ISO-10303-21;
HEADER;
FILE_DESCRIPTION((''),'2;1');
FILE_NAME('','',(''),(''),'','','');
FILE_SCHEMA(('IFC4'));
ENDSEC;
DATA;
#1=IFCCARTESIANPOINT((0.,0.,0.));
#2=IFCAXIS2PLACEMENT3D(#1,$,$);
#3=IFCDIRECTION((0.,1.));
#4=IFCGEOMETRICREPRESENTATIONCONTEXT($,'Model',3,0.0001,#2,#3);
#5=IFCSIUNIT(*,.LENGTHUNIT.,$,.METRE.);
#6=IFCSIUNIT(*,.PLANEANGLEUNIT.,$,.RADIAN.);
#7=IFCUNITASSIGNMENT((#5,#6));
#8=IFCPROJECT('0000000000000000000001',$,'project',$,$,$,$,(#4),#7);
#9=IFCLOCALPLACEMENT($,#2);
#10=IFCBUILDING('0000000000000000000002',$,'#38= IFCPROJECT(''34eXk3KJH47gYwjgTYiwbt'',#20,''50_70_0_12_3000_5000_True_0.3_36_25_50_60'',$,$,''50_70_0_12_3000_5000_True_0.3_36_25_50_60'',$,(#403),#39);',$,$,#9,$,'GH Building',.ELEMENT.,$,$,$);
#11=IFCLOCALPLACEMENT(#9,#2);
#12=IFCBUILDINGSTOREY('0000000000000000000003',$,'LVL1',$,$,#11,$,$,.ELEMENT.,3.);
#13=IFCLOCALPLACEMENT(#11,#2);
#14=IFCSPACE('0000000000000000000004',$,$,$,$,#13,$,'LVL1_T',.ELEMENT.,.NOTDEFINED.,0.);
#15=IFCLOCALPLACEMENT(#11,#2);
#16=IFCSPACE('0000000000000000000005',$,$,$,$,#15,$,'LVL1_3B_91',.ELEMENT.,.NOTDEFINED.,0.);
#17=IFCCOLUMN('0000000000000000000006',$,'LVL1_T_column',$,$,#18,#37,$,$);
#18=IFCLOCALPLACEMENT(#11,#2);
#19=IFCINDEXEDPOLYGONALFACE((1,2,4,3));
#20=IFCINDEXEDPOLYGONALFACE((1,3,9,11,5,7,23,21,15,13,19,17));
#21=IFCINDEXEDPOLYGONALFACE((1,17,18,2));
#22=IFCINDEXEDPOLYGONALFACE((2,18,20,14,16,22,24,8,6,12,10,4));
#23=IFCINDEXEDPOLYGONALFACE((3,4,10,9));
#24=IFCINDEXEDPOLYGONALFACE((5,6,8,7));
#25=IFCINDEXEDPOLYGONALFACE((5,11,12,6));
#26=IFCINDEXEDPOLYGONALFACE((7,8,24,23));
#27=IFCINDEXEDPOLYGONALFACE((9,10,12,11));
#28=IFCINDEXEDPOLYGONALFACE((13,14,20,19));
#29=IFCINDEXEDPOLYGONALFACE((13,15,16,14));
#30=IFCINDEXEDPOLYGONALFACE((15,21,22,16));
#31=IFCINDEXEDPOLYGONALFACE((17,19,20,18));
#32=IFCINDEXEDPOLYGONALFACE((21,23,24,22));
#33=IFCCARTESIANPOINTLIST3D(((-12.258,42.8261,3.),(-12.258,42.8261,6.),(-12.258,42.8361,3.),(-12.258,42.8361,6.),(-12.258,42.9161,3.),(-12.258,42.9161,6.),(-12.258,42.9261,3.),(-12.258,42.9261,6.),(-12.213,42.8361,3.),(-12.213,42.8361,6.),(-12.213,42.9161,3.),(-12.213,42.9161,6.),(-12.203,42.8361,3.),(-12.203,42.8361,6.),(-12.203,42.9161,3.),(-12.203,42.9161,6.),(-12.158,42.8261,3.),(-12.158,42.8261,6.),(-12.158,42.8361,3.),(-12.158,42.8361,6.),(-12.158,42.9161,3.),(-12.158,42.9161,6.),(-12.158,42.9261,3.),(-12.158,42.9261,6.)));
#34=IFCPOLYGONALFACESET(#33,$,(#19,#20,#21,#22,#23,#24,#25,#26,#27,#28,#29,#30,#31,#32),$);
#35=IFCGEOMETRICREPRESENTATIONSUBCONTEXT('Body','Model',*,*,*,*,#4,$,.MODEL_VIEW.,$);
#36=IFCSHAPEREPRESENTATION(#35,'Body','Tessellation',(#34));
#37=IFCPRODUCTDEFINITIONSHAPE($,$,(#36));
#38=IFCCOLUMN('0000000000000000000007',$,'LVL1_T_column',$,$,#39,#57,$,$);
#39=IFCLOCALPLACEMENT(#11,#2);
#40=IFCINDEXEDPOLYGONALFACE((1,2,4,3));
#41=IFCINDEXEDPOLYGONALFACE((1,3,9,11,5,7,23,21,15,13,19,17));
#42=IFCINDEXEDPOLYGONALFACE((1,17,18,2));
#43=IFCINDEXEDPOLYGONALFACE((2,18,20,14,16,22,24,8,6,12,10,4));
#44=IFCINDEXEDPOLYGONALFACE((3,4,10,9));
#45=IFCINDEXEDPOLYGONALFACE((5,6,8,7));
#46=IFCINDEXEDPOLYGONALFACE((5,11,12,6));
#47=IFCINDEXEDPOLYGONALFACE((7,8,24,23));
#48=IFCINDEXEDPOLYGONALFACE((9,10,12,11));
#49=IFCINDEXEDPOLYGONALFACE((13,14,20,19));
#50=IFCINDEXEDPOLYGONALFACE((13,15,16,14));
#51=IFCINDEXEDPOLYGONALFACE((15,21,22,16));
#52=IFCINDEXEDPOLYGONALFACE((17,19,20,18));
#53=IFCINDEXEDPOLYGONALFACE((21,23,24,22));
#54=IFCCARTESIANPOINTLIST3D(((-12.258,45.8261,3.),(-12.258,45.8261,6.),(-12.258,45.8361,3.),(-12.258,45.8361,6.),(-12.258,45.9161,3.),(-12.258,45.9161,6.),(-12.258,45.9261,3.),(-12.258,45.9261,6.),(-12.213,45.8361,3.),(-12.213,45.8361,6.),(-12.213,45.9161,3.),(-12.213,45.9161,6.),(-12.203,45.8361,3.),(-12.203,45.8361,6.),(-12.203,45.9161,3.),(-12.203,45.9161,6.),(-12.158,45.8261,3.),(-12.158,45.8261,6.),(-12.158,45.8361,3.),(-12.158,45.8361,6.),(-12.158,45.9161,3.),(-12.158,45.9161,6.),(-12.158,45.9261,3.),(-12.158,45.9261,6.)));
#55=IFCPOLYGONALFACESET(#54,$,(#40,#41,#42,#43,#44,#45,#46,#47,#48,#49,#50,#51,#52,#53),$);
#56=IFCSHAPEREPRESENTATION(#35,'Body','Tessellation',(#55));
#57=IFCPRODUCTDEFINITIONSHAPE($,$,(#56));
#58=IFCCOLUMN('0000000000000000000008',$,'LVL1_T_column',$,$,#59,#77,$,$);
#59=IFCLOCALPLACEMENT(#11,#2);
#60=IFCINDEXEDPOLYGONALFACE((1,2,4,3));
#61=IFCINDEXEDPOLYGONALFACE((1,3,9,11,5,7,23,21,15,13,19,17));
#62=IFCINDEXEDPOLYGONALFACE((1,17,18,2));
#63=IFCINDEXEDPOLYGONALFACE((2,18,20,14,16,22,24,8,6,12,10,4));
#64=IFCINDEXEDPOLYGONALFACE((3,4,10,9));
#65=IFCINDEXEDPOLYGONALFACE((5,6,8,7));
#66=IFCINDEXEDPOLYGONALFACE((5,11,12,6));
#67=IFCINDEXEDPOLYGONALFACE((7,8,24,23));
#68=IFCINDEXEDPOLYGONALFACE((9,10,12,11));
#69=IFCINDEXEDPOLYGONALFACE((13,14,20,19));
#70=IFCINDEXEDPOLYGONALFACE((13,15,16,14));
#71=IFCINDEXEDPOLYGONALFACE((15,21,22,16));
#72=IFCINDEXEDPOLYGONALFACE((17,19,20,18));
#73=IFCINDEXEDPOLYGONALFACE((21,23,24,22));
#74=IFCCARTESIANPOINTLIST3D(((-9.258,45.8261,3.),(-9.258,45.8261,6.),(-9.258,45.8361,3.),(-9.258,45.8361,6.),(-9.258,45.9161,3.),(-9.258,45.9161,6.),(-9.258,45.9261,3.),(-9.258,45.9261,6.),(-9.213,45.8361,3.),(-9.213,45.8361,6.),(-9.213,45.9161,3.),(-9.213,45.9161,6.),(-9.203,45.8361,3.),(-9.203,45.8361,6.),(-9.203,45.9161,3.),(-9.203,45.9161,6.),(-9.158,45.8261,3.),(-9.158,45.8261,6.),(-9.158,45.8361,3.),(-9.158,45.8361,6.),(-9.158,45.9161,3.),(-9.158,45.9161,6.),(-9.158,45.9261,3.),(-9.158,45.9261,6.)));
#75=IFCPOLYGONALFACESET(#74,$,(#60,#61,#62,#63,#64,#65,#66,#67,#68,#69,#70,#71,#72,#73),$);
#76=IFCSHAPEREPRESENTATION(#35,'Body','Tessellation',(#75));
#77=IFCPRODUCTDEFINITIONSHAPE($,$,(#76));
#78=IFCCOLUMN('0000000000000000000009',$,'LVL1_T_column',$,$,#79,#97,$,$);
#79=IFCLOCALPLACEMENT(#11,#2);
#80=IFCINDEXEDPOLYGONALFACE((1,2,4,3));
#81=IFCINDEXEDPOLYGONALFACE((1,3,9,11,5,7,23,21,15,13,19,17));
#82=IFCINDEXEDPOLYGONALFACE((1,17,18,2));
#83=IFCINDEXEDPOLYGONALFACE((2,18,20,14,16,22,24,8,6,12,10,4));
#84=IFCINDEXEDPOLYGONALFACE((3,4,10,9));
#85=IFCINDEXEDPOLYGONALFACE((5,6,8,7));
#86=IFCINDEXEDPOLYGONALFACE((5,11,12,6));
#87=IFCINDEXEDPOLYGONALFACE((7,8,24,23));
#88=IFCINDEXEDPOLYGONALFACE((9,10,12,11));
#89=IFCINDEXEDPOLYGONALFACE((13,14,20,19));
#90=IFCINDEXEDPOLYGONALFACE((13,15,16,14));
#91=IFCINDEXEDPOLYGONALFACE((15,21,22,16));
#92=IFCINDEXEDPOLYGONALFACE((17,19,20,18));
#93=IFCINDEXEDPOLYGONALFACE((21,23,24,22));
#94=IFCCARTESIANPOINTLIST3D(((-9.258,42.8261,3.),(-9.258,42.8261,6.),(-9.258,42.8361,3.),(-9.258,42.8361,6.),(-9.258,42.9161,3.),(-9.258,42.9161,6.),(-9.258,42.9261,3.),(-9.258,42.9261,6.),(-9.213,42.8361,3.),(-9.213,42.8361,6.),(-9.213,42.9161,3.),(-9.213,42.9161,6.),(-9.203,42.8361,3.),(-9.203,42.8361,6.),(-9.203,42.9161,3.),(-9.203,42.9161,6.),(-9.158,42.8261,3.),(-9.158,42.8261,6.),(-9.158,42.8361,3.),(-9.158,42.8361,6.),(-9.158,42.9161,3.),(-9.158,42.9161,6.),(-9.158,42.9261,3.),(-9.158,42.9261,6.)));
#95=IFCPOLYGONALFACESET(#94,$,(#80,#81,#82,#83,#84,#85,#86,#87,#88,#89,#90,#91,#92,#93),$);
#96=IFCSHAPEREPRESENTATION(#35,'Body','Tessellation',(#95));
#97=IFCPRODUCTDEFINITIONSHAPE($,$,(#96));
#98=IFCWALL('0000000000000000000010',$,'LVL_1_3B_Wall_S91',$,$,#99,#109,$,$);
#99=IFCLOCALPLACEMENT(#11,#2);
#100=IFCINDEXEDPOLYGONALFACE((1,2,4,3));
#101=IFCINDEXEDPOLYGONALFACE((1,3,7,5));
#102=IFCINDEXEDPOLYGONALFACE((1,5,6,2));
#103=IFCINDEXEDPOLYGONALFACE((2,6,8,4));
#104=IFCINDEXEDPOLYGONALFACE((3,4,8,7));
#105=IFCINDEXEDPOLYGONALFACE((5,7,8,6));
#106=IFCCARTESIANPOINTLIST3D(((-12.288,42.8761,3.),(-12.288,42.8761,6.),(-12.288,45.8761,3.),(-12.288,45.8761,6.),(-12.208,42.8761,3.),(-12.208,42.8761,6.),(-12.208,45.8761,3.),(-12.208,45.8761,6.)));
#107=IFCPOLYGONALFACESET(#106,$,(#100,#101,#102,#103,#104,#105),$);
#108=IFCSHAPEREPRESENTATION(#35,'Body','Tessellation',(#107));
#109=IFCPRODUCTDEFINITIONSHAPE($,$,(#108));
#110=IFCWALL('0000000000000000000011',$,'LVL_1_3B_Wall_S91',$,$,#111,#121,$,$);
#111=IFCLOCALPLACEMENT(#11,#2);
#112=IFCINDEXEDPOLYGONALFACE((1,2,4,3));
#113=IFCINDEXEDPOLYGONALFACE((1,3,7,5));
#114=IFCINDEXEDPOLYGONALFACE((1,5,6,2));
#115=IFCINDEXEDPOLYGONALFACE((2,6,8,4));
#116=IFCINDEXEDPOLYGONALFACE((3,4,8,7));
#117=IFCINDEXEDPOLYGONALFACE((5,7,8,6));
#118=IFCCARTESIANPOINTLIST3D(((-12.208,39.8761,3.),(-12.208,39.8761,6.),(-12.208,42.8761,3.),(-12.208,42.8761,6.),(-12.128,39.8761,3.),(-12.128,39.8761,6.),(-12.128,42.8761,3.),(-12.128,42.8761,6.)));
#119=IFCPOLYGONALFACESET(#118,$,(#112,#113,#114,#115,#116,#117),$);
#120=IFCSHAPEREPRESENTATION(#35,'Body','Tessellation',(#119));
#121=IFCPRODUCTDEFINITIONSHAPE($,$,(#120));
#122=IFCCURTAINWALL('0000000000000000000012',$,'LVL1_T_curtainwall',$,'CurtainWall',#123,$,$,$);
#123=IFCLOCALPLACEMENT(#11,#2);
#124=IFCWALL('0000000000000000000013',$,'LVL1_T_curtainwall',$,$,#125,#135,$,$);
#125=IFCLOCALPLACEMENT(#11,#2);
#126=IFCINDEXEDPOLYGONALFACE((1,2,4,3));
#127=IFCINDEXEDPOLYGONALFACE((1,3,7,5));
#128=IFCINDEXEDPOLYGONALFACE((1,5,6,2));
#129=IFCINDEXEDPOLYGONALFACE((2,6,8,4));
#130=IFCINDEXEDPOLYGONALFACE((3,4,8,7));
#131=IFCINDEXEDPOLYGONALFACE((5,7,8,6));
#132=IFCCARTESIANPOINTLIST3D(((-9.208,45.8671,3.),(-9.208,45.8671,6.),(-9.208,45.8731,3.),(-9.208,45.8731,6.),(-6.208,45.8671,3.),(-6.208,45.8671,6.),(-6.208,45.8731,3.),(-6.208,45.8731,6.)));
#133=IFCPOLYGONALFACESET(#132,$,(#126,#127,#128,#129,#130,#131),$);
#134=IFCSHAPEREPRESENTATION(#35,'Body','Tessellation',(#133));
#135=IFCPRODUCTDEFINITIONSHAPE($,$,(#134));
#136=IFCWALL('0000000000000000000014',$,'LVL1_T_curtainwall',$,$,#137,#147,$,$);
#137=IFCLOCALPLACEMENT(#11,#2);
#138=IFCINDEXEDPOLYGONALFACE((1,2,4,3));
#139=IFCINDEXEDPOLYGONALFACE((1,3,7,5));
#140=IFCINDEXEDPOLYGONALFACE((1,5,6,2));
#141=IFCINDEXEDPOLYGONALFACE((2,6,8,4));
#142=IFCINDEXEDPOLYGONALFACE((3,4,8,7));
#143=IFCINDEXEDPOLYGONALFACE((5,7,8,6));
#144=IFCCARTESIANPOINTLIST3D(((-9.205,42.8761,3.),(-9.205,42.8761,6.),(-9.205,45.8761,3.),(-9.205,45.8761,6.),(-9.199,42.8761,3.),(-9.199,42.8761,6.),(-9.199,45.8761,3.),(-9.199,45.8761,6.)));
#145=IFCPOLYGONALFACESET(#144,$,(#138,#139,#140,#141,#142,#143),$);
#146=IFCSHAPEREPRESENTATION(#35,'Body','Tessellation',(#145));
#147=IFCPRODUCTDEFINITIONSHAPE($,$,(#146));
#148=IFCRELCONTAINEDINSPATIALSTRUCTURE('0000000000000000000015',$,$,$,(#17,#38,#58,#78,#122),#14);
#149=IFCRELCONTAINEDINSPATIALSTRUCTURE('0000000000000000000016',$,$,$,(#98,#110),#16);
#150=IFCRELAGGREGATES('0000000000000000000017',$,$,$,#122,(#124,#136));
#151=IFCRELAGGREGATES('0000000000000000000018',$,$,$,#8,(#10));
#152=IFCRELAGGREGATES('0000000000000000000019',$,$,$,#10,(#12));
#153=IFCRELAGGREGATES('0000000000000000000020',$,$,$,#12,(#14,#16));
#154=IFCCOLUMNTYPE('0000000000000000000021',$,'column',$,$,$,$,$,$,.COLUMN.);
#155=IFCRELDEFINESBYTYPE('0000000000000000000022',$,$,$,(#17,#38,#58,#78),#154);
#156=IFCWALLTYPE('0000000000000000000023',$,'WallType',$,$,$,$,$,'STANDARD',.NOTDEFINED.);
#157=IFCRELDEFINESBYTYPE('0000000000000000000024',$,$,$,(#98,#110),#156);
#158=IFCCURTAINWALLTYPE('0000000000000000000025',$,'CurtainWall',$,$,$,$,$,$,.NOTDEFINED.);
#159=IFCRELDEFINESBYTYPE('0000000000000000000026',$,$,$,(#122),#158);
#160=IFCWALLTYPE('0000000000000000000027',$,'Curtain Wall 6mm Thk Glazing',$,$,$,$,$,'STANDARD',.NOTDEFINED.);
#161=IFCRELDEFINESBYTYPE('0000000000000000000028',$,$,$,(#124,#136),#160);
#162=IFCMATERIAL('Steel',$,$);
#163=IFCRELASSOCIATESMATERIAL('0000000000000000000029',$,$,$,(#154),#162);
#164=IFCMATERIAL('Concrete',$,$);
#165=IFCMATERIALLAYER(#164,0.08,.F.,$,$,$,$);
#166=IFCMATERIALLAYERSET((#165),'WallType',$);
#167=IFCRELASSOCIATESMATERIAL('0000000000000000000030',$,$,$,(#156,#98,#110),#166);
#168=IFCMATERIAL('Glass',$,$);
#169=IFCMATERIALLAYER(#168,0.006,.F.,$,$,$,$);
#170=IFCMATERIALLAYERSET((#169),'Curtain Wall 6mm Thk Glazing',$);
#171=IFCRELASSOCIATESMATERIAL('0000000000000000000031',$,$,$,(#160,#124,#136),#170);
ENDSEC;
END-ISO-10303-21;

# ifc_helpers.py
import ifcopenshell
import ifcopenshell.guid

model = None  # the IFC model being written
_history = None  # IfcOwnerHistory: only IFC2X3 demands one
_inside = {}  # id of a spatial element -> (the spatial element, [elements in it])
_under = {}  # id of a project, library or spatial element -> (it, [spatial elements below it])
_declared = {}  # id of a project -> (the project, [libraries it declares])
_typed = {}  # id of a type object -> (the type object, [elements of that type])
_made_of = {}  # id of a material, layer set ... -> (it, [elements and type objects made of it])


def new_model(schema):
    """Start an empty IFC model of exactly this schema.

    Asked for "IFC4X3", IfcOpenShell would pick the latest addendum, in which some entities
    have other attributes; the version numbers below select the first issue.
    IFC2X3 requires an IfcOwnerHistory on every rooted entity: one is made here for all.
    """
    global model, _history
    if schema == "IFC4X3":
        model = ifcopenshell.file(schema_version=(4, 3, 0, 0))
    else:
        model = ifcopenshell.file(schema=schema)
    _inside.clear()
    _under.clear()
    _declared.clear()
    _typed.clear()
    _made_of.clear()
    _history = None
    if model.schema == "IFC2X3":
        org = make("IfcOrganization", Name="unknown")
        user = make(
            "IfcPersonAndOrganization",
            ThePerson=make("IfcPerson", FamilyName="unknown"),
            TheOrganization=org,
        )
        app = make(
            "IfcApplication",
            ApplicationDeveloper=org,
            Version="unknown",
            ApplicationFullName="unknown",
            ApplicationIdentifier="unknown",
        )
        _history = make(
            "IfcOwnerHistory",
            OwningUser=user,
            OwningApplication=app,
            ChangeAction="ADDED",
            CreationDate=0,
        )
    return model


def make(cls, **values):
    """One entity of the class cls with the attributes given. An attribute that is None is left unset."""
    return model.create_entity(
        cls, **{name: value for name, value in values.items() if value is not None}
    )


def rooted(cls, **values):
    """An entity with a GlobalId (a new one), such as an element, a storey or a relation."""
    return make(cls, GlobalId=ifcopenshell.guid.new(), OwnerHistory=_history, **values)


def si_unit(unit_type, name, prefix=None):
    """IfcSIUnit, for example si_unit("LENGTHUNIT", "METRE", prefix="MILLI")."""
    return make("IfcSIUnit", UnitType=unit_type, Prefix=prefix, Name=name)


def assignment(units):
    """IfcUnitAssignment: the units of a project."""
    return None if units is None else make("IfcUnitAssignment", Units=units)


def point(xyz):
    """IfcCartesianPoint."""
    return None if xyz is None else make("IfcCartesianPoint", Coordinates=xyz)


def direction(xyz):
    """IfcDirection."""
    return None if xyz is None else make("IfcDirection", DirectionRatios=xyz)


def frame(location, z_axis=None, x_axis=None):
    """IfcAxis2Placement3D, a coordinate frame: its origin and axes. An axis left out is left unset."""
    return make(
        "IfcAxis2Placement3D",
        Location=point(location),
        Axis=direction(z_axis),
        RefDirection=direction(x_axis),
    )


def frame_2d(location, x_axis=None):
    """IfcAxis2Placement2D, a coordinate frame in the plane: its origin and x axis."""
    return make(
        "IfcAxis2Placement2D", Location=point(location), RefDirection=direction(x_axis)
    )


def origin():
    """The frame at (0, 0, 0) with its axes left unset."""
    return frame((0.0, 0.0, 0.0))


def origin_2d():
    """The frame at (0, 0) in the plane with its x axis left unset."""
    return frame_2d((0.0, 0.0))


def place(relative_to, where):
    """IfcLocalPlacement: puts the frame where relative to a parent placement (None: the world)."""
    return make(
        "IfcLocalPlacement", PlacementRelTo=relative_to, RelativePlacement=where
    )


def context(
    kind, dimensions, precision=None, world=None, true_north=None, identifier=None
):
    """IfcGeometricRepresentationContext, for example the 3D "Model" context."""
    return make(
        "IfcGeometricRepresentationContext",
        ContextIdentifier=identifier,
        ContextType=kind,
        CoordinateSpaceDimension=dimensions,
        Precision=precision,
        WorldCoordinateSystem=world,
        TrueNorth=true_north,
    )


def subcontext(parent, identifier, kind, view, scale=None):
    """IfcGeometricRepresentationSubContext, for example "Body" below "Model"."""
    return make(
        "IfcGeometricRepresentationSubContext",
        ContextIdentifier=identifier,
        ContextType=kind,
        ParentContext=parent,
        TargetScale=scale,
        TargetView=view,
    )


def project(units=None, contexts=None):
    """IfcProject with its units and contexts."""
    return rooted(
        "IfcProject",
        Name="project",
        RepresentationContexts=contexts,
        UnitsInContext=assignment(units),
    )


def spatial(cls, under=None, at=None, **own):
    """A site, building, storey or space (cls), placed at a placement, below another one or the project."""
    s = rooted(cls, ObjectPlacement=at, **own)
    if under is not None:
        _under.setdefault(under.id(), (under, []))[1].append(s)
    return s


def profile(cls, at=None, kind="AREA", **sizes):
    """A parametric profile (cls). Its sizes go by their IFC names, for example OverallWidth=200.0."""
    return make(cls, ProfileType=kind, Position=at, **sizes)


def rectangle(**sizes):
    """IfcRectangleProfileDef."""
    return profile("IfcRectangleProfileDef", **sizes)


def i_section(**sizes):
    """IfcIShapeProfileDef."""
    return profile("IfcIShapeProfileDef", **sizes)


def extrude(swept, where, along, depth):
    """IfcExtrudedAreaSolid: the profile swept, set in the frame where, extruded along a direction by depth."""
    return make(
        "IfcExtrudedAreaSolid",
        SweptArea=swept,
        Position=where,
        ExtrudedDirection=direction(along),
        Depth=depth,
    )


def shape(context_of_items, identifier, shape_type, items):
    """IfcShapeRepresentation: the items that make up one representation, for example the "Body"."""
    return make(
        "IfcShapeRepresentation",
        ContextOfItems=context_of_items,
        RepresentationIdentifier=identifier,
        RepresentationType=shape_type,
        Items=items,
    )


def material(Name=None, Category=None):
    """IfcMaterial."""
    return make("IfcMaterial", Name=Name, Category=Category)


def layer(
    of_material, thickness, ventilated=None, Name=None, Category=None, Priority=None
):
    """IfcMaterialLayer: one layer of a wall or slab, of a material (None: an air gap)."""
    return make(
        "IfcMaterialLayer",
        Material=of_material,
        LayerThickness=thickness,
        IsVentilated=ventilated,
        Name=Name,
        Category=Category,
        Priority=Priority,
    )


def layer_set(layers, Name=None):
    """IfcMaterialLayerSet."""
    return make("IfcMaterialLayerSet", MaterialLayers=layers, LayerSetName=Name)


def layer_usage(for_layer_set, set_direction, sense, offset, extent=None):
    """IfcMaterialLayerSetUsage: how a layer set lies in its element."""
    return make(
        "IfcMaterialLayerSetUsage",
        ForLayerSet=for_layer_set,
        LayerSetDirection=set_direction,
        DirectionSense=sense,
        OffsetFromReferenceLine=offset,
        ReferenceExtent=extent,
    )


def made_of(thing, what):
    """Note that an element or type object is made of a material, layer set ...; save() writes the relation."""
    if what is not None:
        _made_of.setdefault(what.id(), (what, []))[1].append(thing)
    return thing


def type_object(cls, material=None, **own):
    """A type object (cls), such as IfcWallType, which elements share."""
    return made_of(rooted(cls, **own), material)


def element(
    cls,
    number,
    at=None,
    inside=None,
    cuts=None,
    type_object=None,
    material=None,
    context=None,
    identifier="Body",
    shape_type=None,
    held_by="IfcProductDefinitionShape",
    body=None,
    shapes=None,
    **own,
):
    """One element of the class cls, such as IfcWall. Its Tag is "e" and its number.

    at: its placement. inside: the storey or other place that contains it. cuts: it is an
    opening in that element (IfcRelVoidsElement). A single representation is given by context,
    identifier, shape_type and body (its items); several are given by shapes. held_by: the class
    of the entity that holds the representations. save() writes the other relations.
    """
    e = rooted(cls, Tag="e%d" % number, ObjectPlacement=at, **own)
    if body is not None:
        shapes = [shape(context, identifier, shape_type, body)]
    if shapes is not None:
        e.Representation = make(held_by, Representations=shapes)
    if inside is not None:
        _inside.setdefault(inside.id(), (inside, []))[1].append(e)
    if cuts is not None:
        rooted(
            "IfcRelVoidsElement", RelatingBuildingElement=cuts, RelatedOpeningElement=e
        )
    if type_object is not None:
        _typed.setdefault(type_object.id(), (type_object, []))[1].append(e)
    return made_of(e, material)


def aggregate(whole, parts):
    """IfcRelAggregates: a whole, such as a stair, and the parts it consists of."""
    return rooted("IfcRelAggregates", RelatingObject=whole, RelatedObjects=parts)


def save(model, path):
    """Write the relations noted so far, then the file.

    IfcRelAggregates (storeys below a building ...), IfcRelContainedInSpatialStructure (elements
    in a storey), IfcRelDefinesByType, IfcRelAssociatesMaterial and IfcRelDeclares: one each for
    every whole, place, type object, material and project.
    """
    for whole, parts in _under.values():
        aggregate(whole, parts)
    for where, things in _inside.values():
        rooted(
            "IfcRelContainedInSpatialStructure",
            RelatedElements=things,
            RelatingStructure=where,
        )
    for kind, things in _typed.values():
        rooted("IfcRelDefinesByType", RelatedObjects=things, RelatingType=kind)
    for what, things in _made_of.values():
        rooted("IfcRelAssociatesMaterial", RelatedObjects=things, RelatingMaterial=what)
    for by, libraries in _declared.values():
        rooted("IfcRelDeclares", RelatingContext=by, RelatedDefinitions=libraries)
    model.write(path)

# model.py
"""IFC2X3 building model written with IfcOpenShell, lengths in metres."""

from ifc_helpers import new_model, si_unit, direction, frame, frame_2d, origin, origin_2d, place, context, subcontext, project, spatial, rectangle, i_section, extrude, material, layer, layer_set, layer_usage, type_object, element, aggregate, save


model = new_model("IFC2X3")

# Units and contexts
model_context = context("Model", 3, precision=0.0001, world=origin(), true_north=direction((0.0, 1.0)))
body_context = subcontext(model_context, "Body", "Model", "MODEL_VIEW")
ifc_project = project(units=[si_unit("LENGTHUNIT", "METRE"), si_unit("PLANEANGLEUNIT", "RADIAN")], contexts=[model_context])

# Building, storey, space
building_placement = place(None, origin())
building = spatial("IfcBuilding", under=ifc_project, at=building_placement, Name="#38= IFCPROJECT('34eXk3KJH47gYwjgTYiwbt',#20,'50_70_0_12_3000_5000_True_0.3_36_25_50_60',$,$,'50_70_0_12_3000_5000_True_0.3_36_25_50_60',$,(#403),#39);", LongName="GH Building", CompositionType="ELEMENT")
storey_placement = place(building_placement, origin())
storey = spatial("IfcBuildingStorey", under=building, at=storey_placement, Name="LVL1", CompositionType="ELEMENT", Elevation=3.0)
space_1_placement = place(storey_placement, origin())
space_1 = spatial("IfcSpace", under=storey, at=space_1_placement, LongName="LVL1_T", CompositionType="ELEMENT", InteriorOrExteriorSpace="NOTDEFINED", ElevationWithFlooring=0.0)

# Columns
ifc_material_1 = material(Name="Steel")
column_type = type_object("IfcColumnType", Name="column", PredefinedType="COLUMN", material=ifc_material_1)
for number, where, name in (
    (1, (-12.208, 42.8761, 3.0), "LVL1_T_column"),
    (2, (-12.208, 45.8761, 3.0), "LVL1_T_column"),
    (3, (-9.208, 45.8761, 3.0), "LVL1_T_column"),
    (4, (-9.208, 42.8761, 3.0), "LVL1_T_column"),
):
    element("IfcColumn", number, at=place(space_1_placement, frame(where)), inside=space_1, type_object=column_type, Name=name, context=body_context, shape_type="SweptSolid", body=[
        extrude(i_section(OverallWidth=0.1, OverallDepth=0.1, WebThickness=0.01, FlangeThickness=0.01, at=origin_2d()), origin(), (0.0, 0.0, 1.0), 3.0),
    ])

# Shared definitions
ifc_material_2 = material(Name="Concrete")
ifc_layer_1 = layer(ifc_material_2, 0.08, ventilated=False)
ifc_layer_set_1 = layer_set([ifc_layer_1], Name="WallType")
wall_type_1 = type_object("IfcWallType", Name="WallType", ElementType="STANDARD", PredefinedType="NOTDEFINED", material=ifc_layer_set_1)

# Shared definitions
space_2_placement = place(storey_placement, origin())
space_2 = spatial("IfcSpace", under=storey, at=space_2_placement, LongName="LVL1_3B_91", CompositionType="ELEMENT", InteriorOrExteriorSpace="NOTDEFINED", ElevationWithFlooring=0.0)

# Walls
ifc_layer_usage_1 = layer_usage(ifc_layer_set_1, "AXIS2", "NEGATIVE", 0.0)
wall_1_placement = place(space_2_placement, frame((-12.208, 45.8761, 3.0), z_axis=(0.0, 0.0, 1.0), x_axis=(0.0, -1.0, 0.0)))
element("IfcWall", 5, at=wall_1_placement, inside=space_2, type_object=wall_type_1, material=ifc_layer_usage_1, Name="LVL_1_3B_Wall_S91", context=body_context, shape_type="SweptSolid", body=[
    extrude(rectangle(XDim=3.0, YDim=0.08, at=frame_2d((1.5, -0.04))), origin(), (0.0, 0.0, 1.0), 3.0),
])
ifc_layer_usage_2 = layer_usage(ifc_layer_set_1, "AXIS2", "NEGATIVE", 0.0)
wall_2_placement = place(space_2_placement, frame((-12.208, 39.8761, 3.0), z_axis=(0.0, 0.0, 1.0), x_axis=(0.0, 1.0, 0.0)))
element("IfcWall", 6, at=wall_2_placement, inside=space_2, type_object=wall_type_1, material=ifc_layer_usage_2, Name="LVL_1_3B_Wall_S91", context=body_context, shape_type="SweptSolid", body=[
    extrude(rectangle(XDim=3.0, YDim=0.08, at=frame_2d((1.5, -0.04))), origin(), (0.0, 0.0, 1.0), 3.0),
])

# Curtain wall, walls
curtain_wall_type = type_object("IfcCurtainWallType", Name="CurtainWall", PredefinedType="NOTDEFINED")
curtain_wall_placement = place(None, origin())
curtain_wall = element("IfcCurtainWall", 7, at=curtain_wall_placement, inside=space_1, type_object=curtain_wall_type, Name="LVL1_T_curtainwall", ObjectType="CurtainWall")
ifc_material_3 = material(Name="Glass")
ifc_layer_2 = layer(ifc_material_3, 0.006, ventilated=False)
ifc_layer_set_2 = layer_set([ifc_layer_2], Name="Curtain Wall 6mm Thk Glazing")
ifc_layer_usage_3 = layer_usage(ifc_layer_set_2, "AXIS2", "NEGATIVE", -0.003)
wall_type_2 = type_object("IfcWallType", Name="Curtain Wall 6mm Thk Glazing", ElementType="STANDARD", PredefinedType="NOTDEFINED", material=ifc_layer_set_2)
wall_3_placement = place(curtain_wall_placement, frame((-9.208, 45.8761, 3.0)))
wall_3 = element("IfcWall", 8, at=wall_3_placement, type_object=wall_type_2, material=ifc_layer_usage_3, Name="LVL1_T_curtainwall", context=body_context, shape_type="SweptSolid", body=[
    extrude(rectangle(XDim=3.0, YDim=0.006, at=frame_2d((1.5, -0.006))), origin(), (0.0, 0.0, 1.0), 3.0),
])
ifc_layer_usage_4 = layer_usage(ifc_layer_set_2, "AXIS2", "NEGATIVE", -0.003)
wall_4_placement = place(curtain_wall_placement, frame((-9.208, 42.8761, 3.0), z_axis=(0.0, 0.0, 1.0), x_axis=(0.0, 1.0, 0.0)))
wall_4 = element("IfcWall", 9, at=wall_4_placement, type_object=wall_type_2, material=ifc_layer_usage_4, Name="LVL1_T_curtainwall", context=body_context, shape_type="SweptSolid", body=[
    extrude(rectangle(XDim=3.0, YDim=0.006, at=frame_2d((1.5, -0.006))), origin(), (0.0, 0.0, 1.0), 3.0),
])
aggregate(curtain_wall, [wall_3, wall_4])

save(model, "model.ifc")
